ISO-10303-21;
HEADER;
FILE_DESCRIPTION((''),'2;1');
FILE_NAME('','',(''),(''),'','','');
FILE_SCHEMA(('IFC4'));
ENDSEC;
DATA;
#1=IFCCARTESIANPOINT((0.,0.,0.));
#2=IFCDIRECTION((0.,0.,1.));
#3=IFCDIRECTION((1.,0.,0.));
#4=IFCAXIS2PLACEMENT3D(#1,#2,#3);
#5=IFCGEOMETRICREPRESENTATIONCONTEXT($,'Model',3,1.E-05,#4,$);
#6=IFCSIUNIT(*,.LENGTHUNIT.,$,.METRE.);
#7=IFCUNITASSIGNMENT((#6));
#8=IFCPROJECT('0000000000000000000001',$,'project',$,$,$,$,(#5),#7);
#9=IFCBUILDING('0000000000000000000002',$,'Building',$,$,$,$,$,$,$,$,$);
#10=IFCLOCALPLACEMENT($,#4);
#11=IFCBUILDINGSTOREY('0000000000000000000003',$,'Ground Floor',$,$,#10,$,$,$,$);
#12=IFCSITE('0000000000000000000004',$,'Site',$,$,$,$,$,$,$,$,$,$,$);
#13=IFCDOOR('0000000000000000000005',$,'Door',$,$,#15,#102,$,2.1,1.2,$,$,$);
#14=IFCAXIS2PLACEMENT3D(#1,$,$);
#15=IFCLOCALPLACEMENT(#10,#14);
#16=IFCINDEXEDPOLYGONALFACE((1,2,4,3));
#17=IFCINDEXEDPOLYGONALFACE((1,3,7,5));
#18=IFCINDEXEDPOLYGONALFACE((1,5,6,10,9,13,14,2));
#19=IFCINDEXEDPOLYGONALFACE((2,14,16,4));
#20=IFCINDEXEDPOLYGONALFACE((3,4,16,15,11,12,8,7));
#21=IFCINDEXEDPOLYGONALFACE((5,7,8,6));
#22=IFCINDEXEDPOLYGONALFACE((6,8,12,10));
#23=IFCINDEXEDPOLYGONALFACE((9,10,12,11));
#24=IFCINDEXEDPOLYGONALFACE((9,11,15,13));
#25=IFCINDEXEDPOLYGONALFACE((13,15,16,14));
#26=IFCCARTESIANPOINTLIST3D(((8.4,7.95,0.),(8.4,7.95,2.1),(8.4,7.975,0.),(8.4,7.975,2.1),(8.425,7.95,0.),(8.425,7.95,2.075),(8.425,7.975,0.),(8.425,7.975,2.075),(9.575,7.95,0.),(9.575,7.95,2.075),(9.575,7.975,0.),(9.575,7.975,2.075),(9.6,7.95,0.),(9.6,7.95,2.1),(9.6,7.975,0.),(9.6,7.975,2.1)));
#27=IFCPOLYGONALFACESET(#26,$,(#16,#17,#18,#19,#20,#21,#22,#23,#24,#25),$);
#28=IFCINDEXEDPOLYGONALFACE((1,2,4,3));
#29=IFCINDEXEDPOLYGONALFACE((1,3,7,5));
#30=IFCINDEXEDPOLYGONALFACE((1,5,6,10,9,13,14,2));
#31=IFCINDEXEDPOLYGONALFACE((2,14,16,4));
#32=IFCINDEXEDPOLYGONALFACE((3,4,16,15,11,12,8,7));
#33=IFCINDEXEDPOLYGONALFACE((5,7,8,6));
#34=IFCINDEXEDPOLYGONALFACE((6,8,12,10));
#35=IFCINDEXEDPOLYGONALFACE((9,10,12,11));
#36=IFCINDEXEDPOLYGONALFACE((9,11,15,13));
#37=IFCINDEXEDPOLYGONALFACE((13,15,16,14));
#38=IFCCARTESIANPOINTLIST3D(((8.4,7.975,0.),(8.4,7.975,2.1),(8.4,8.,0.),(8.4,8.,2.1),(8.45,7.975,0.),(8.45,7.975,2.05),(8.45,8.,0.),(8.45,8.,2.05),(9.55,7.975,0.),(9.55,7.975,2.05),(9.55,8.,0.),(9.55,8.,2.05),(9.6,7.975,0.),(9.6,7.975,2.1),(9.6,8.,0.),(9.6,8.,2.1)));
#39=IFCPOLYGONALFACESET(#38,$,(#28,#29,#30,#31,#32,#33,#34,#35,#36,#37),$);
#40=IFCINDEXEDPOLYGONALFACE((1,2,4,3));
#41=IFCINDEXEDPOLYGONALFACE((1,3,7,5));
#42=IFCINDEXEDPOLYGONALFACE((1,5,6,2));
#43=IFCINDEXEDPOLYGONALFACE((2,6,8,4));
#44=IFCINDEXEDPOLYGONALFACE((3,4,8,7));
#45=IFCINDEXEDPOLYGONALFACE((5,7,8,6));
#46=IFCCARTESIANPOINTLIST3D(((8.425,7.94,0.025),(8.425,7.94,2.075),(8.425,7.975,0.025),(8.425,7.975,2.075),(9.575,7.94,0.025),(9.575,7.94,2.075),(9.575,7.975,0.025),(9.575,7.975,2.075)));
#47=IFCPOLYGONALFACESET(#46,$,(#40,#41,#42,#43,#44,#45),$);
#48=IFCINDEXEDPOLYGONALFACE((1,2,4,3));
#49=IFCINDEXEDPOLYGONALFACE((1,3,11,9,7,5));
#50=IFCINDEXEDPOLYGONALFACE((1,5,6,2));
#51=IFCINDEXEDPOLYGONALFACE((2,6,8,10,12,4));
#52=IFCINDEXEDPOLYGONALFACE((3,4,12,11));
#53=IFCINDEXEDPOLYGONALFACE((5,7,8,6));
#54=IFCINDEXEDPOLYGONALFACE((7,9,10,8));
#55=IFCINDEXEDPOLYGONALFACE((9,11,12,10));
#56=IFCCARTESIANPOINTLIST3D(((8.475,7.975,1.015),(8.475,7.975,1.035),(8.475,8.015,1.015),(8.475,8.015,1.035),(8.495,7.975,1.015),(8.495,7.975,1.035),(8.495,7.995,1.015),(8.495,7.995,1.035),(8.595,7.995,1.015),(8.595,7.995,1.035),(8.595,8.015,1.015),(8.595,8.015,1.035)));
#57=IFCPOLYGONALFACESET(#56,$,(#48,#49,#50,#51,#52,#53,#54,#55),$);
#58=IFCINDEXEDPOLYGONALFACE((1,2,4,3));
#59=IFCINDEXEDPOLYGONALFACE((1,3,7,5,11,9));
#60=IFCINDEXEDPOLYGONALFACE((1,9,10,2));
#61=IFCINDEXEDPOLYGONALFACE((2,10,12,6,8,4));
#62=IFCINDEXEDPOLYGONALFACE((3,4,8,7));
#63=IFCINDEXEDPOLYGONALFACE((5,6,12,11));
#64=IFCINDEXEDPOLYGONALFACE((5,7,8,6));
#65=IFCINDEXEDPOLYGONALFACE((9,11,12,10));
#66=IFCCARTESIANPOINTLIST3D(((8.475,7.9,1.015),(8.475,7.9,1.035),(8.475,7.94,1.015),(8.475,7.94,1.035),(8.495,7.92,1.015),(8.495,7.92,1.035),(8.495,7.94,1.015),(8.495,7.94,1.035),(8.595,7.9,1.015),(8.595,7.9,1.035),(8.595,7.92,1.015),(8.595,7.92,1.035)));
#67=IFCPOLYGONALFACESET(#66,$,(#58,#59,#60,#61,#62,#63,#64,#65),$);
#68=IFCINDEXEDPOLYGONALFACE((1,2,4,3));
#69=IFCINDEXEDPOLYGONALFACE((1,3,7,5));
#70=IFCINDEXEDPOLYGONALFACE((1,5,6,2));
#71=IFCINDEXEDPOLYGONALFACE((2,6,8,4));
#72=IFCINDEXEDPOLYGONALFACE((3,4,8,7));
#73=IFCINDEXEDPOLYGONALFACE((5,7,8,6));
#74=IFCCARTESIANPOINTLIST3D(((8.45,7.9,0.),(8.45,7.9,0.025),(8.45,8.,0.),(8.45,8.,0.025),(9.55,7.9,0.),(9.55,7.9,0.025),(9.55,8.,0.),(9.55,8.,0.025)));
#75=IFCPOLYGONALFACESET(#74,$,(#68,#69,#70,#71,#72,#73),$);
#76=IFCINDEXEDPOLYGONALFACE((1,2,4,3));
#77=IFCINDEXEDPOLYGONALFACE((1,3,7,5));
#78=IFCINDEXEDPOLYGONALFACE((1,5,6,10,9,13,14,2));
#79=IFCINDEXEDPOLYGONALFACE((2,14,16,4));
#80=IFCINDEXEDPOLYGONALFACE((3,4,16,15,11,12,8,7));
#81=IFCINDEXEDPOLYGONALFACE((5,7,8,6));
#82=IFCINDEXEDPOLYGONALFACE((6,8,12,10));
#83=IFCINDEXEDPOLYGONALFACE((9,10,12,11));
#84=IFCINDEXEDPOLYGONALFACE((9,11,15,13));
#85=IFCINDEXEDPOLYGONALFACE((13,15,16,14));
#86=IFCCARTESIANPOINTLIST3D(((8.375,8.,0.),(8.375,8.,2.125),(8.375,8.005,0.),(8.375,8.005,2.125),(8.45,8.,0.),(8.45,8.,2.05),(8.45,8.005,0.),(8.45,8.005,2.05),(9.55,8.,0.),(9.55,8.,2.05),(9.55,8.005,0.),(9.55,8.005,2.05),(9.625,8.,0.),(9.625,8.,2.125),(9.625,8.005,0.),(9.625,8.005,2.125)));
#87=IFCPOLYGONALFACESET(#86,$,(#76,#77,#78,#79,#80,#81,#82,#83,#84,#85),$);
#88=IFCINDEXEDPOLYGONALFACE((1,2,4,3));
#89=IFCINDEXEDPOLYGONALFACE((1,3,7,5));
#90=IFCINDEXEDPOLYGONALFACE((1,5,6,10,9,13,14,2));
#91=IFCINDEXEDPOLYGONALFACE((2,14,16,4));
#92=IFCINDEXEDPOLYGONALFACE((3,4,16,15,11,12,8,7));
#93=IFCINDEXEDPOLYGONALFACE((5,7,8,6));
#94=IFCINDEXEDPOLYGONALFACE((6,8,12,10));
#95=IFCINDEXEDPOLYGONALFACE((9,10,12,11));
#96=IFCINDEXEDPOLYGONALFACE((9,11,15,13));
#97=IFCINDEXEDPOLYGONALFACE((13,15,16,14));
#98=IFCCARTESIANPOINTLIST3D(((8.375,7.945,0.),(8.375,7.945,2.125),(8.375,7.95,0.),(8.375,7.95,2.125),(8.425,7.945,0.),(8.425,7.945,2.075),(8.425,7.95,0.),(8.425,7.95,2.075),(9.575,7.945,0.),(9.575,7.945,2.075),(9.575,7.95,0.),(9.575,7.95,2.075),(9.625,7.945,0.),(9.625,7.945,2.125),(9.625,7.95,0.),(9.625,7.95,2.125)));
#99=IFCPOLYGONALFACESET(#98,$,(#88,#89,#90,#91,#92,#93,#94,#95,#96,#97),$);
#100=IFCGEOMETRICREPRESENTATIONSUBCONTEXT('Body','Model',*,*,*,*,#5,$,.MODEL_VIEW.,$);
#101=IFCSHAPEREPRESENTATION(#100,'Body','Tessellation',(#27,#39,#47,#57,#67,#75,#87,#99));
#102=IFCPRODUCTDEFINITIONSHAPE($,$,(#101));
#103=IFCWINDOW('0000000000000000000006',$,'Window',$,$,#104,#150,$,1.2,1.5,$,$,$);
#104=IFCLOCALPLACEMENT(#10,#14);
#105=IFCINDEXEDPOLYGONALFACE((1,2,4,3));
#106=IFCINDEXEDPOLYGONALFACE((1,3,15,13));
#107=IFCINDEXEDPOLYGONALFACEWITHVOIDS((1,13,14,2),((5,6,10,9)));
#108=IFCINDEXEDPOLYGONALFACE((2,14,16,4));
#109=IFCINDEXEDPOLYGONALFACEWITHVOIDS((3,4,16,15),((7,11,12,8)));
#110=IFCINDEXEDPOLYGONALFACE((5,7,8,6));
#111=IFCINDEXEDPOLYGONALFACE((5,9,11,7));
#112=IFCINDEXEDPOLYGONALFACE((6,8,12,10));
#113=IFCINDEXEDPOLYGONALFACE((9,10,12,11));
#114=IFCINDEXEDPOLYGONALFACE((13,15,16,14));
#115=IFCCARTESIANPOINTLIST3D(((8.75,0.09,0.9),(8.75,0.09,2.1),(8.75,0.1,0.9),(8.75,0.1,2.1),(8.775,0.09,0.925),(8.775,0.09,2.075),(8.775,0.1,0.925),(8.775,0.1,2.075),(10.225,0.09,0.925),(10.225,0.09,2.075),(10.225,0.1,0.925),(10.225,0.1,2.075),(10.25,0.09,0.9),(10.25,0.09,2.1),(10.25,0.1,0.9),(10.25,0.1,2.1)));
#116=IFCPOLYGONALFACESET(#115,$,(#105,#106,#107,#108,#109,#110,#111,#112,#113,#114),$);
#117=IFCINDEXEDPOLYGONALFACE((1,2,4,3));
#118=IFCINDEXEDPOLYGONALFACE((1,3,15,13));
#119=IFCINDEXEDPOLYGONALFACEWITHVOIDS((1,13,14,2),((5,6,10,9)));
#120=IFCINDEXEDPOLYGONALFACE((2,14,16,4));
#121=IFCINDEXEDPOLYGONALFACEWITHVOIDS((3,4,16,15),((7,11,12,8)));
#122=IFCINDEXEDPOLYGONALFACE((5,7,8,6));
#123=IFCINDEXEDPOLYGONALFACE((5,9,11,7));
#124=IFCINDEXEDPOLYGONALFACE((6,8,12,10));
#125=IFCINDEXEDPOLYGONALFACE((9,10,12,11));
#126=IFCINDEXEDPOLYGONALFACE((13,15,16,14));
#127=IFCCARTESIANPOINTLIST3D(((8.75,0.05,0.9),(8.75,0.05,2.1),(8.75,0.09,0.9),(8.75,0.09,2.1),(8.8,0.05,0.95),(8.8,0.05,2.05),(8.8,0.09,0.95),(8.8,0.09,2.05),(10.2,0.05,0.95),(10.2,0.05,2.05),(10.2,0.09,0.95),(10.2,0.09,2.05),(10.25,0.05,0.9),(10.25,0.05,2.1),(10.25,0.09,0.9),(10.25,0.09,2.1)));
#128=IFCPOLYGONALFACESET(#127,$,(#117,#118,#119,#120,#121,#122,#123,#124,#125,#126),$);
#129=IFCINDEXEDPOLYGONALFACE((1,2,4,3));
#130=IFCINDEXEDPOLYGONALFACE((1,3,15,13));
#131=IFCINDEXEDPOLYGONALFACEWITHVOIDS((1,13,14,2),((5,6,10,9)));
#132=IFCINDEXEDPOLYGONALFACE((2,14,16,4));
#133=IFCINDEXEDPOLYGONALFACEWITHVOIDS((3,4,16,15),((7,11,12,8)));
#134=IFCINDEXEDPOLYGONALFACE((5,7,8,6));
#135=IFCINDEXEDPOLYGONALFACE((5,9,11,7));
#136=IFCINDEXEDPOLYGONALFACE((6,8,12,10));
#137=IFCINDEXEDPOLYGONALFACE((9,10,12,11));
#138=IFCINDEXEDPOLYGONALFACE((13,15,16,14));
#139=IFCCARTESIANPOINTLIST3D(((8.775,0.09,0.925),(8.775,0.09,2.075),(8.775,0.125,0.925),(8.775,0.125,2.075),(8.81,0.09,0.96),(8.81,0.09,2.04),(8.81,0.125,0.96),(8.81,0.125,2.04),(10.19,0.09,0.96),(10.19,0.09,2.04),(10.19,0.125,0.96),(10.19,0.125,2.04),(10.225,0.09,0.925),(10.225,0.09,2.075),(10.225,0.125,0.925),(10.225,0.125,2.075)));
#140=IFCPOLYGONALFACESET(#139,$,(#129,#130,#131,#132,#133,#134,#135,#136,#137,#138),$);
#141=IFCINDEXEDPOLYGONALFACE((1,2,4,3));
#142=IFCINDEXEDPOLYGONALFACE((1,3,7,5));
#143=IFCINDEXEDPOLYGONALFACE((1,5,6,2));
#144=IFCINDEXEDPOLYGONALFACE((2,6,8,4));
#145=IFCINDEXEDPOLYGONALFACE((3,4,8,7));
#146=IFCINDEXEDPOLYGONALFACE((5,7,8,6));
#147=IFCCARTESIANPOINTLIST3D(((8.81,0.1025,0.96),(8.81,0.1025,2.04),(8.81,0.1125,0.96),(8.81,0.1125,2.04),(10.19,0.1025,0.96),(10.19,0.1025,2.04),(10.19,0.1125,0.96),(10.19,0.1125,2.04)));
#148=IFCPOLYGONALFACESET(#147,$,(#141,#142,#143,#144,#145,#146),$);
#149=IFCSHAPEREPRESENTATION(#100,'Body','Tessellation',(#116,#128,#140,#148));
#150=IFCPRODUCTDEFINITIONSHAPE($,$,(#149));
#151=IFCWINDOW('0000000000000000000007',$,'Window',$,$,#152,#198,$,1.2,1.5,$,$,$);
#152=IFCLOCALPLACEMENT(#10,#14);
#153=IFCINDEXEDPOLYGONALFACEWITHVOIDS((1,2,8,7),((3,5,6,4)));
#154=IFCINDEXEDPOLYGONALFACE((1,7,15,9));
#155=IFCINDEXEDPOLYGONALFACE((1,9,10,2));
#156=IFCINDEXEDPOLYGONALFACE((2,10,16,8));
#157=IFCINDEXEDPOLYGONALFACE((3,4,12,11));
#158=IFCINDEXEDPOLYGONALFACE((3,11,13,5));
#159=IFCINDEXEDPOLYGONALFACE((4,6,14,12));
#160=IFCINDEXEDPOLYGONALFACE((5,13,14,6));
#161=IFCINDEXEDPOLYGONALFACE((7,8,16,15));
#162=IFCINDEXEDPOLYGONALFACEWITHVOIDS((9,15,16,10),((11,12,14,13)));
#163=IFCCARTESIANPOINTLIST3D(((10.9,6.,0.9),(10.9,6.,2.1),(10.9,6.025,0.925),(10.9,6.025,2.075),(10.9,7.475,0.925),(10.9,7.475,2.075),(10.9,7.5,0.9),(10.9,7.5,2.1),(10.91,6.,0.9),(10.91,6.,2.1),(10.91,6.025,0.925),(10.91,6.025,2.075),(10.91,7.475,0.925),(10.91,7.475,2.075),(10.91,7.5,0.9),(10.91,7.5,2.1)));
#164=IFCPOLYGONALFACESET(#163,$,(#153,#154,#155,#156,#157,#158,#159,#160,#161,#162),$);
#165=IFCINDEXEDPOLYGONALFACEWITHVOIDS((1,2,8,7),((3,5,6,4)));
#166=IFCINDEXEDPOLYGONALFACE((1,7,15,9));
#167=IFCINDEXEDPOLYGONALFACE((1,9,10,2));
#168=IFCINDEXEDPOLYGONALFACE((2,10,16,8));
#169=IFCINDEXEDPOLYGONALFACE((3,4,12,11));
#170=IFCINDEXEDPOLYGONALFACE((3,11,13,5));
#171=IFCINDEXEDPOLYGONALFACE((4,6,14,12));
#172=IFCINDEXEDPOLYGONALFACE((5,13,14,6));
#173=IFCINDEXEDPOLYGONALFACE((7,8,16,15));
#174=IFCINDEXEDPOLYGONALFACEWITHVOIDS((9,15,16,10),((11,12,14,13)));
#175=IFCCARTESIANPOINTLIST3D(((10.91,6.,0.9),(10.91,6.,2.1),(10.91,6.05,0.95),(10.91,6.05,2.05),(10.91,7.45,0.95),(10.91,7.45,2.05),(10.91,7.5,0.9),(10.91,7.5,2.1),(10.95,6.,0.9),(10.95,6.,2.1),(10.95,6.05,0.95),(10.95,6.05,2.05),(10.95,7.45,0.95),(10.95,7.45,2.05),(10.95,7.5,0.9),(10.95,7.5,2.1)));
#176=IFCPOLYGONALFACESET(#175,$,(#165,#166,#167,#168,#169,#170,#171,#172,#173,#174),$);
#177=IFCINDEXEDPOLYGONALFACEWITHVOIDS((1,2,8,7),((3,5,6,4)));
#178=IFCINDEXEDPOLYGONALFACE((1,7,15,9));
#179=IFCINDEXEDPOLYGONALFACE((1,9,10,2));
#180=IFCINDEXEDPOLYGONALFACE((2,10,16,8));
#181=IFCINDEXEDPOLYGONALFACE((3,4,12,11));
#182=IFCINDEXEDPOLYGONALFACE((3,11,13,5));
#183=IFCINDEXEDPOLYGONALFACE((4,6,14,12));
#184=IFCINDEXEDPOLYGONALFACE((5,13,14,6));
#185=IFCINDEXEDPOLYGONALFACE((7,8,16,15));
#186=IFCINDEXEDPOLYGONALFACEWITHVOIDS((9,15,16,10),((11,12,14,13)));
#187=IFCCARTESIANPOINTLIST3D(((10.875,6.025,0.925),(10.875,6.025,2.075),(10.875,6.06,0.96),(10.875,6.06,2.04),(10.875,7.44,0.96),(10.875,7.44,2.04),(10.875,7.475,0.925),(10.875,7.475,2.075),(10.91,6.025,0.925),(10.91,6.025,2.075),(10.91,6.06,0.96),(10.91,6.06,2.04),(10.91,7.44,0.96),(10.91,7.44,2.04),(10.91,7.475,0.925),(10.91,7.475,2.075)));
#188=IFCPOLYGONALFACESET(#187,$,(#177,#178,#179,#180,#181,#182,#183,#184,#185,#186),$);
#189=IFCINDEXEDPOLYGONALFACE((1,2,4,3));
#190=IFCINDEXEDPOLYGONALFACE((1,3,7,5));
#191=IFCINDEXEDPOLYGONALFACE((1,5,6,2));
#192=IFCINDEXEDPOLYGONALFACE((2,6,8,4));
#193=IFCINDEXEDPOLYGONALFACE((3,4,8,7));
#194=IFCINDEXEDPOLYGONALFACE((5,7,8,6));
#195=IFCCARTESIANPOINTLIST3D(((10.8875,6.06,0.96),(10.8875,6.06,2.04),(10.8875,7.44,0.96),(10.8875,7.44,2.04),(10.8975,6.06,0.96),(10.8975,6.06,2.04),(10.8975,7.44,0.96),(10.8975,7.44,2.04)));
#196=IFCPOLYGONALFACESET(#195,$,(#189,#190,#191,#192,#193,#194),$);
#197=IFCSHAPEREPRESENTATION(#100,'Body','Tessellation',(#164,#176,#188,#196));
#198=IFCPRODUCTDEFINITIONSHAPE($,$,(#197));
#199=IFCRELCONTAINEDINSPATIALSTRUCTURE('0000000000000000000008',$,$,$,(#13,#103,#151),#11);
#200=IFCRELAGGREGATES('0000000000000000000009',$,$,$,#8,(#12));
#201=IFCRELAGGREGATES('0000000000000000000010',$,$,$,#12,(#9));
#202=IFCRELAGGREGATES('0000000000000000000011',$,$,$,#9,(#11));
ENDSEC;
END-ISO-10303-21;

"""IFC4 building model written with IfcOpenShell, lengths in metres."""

from ifc_helpers import new_model, si_unit, frame, origin_with_axes, place, context, subcontext, project, spatial, line, indexed_curve, outline, extrude, element, save


model = new_model("IFC4")

# Units and contexts
model_context = context("Model", 3, precision=1e-05, world=origin_with_axes())
body_context = subcontext(model_context, "Body", "Model", "MODEL_VIEW")
ifc_project = project(units=[si_unit("LENGTHUNIT", "METRE")], contexts=[model_context])

# Site, building, storey
site = spatial("IfcSite", under=ifc_project, Name="Site")
building = spatial("IfcBuilding", under=site, Name="Building")
storey_placement = place(None, origin_with_axes())
storey = spatial("IfcBuildingStorey", under=building, at=storey_placement, Name="Ground Floor")

# Door
door_1_placement = place(storey_placement, frame((9.6, 8.0, 0.0), z_axis=(0.0, 0.0, 1.0), x_axis=(-1.0, 0.0, 0.0)))
element("IfcDoor", 1, at=door_1_placement, inside=storey, Name="Door", OverallHeight=2.1, OverallWidth=1.2, context=body_context, shape_type="SweptSolid", body=[
    extrude(outline(indexed_curve([(0.0, 0.0), (0.0, 2.1), (1.2, 2.1), (1.2, 0.0), (1.175, 0.0), (1.175, 2.075), (0.025, 2.075), (0.025, 0.0)], segments=[line(1, 2, 3, 4, 5, 6, 7, 8, 1)])), frame((0.0, 0.025, 0.0), z_axis=(0.0, -1.0, 0.0), x_axis=(1.0, 0.0, 0.0)), (0.0, 0.0, -1.0), 0.025),
    extrude(outline(indexed_curve([(0.0, 0.0), (0.0, 2.1), (1.2, 2.1), (1.2, 0.0), (1.15, 0.0), (1.15, 2.05), (0.05, 2.05), (0.05, 0.0)], segments=[line(1, 2, 3, 4, 5, 6, 7, 8, 1)])), frame((0.0, 0.0, 0.0), z_axis=(0.0, -1.0, 0.0), x_axis=(1.0, 0.0, 0.0)), (0.0, 0.0, -1.0), 0.025),
    extrude(outline(indexed_curve([(0.0, 0.0), (1.15, 0.0), (1.15, 0.035), (0.0, 0.035)], segments=[line(1, 2, 3, 4, 1)])), frame((0.025, 0.025, 0.025), z_axis=(0.0, 0.0, 1.0), x_axis=(1.0, 0.0, 0.0)), (0.0, 0.0, 1.0), 2.05),
    extrude(outline(indexed_curve([(0.0, 0.0), (0.0, -0.04), (-0.12, -0.04), (-0.12, -0.02), (-0.02, -0.02), (-0.02, 0.0)], segments=[line(1, 2, 3, 4, 5, 6, 1)])), frame((1.125, 0.025, 1.015), z_axis=(0.0, 0.0, 1.0), x_axis=(1.0, 0.0, 0.0)), (0.0, 0.0, 1.0), 0.02),
    extrude(outline(indexed_curve([(0.0, 0.0), (0.0, 0.04), (-0.12, 0.04), (-0.12, 0.02), (-0.02, 0.02), (-0.02, 0.0)], segments=[line(1, 2, 3, 4, 5, 6, 1)])), frame((1.125, 0.06, 1.015), z_axis=(0.0, 0.0, 1.0), x_axis=(1.0, 0.0, 0.0)), (0.0, 0.0, 1.0), 0.02),
    extrude(outline(indexed_curve([(0.0, 0.0), (1.1, 0.0), (1.1, 0.1), (0.0, 0.1)], segments=[line(1, 2, 3, 4, 1)])), frame((0.05, 0.0, 0.0), z_axis=(0.0, 0.0, 1.0), x_axis=(1.0, 0.0, 0.0)), (0.0, 0.0, 1.0), 0.025),
    extrude(outline(indexed_curve([(0.0, 0.0), (0.0, 2.125), (1.25, 2.125), (1.25, 0.0), (1.175, 0.0), (1.175, 2.05), (0.075, 2.05), (0.075, 0.0)], segments=[line(1, 2, 3, 4, 5, 6, 7, 8, 1)])), frame((-0.025, -0.005, 0.0), z_axis=(0.0, -1.0, 0.0), x_axis=(1.0, 0.0, 0.0)), (0.0, 0.0, -1.0), 0.005),
    extrude(outline(indexed_curve([(0.0, 0.0), (0.0, 2.125), (1.25, 2.125), (1.25, 0.0), (1.2, 0.0), (1.2, 2.075), (0.05, 2.075), (0.05, 0.0)], segments=[line(1, 2, 3, 4, 5, 6, 7, 8, 1)])), frame((-0.025, 0.05, 0.0), z_axis=(0.0, -1.0, 0.0), x_axis=(1.0, 0.0, 0.0)), (0.0, 0.0, -1.0), 0.005),
])

# Windows
for number, where, z_axis, x_axis, name in (
    (2, (8.75, 0.0, 0.9), (0.0, 0.0, 1.0), (1.0, 0.0, 0.0), "Window"),
    (3, (11.0, 6.0, 0.9), (0.0, 0.0, 1.0), (0.0, 1.0, 0.0), "Window"),
):
    element("IfcWindow", number, at=place(storey_placement, frame(where, z_axis=z_axis, x_axis=x_axis)), inside=storey, Name=name, OverallHeight=1.2, OverallWidth=1.5, context=body_context, shape_type="SweptSolid", body=[
        extrude(outline(indexed_curve([(0.0, 0.0), (1.5, 0.0), (1.5, 1.2), (0.0, 1.2)], segments=[line(1, 2, 3, 4, 1)]), holes=[indexed_curve([(0.025, 0.025), (1.475, 0.025), (1.475, 1.175), (0.025, 1.175)], segments=[line(1, 2, 3, 4, 1)])]), frame((0.0, 0.09, 0.0), z_axis=(0.0, -1.0, 0.0), x_axis=(1.0, 0.0, 0.0)), (0.0, 0.0, -1.0), 0.01),
        extrude(outline(indexed_curve([(0.0, 0.0), (1.5, 0.0), (1.5, 1.2), (0.0, 1.2)], segments=[line(1, 2, 3, 4, 1)]), holes=[indexed_curve([(0.05, 0.05), (1.45, 0.05), (1.45, 1.15), (0.05, 1.15)], segments=[line(1, 2, 3, 4, 1)])]), frame((0.0, 0.05, 0.0), z_axis=(0.0, -1.0, 0.0), x_axis=(1.0, 0.0, 0.0)), (0.0, 0.0, -1.0), 0.04),
        extrude(outline(indexed_curve([(0.0, 0.0), (1.45, 0.0), (1.45, 1.15), (0.0, 1.15)], segments=[line(1, 2, 3, 4, 1)]), holes=[indexed_curve([(0.035, 0.035), (1.415, 0.035), (1.415, 1.115), (0.035, 1.115)], segments=[line(1, 2, 3, 4, 1)])]), frame((0.025, 0.09, 0.025), z_axis=(0.0, -1.0, 0.0), x_axis=(1.0, 0.0, 0.0)), (0.0, 0.0, -1.0), 0.035),
        extrude(outline(indexed_curve([(0.035, 0.035), (1.415, 0.035), (1.415, 1.115), (0.035, 1.115)], segments=[line(1, 2, 3, 4, 1)])), frame((0.025, 0.1025, 0.025), z_axis=(0.0, -1.0, 0.0), x_axis=(1.0, 0.0, 0.0)), (0.0, 0.0, -1.0), 0.01),
    ])

save(model, "model.ifc")
